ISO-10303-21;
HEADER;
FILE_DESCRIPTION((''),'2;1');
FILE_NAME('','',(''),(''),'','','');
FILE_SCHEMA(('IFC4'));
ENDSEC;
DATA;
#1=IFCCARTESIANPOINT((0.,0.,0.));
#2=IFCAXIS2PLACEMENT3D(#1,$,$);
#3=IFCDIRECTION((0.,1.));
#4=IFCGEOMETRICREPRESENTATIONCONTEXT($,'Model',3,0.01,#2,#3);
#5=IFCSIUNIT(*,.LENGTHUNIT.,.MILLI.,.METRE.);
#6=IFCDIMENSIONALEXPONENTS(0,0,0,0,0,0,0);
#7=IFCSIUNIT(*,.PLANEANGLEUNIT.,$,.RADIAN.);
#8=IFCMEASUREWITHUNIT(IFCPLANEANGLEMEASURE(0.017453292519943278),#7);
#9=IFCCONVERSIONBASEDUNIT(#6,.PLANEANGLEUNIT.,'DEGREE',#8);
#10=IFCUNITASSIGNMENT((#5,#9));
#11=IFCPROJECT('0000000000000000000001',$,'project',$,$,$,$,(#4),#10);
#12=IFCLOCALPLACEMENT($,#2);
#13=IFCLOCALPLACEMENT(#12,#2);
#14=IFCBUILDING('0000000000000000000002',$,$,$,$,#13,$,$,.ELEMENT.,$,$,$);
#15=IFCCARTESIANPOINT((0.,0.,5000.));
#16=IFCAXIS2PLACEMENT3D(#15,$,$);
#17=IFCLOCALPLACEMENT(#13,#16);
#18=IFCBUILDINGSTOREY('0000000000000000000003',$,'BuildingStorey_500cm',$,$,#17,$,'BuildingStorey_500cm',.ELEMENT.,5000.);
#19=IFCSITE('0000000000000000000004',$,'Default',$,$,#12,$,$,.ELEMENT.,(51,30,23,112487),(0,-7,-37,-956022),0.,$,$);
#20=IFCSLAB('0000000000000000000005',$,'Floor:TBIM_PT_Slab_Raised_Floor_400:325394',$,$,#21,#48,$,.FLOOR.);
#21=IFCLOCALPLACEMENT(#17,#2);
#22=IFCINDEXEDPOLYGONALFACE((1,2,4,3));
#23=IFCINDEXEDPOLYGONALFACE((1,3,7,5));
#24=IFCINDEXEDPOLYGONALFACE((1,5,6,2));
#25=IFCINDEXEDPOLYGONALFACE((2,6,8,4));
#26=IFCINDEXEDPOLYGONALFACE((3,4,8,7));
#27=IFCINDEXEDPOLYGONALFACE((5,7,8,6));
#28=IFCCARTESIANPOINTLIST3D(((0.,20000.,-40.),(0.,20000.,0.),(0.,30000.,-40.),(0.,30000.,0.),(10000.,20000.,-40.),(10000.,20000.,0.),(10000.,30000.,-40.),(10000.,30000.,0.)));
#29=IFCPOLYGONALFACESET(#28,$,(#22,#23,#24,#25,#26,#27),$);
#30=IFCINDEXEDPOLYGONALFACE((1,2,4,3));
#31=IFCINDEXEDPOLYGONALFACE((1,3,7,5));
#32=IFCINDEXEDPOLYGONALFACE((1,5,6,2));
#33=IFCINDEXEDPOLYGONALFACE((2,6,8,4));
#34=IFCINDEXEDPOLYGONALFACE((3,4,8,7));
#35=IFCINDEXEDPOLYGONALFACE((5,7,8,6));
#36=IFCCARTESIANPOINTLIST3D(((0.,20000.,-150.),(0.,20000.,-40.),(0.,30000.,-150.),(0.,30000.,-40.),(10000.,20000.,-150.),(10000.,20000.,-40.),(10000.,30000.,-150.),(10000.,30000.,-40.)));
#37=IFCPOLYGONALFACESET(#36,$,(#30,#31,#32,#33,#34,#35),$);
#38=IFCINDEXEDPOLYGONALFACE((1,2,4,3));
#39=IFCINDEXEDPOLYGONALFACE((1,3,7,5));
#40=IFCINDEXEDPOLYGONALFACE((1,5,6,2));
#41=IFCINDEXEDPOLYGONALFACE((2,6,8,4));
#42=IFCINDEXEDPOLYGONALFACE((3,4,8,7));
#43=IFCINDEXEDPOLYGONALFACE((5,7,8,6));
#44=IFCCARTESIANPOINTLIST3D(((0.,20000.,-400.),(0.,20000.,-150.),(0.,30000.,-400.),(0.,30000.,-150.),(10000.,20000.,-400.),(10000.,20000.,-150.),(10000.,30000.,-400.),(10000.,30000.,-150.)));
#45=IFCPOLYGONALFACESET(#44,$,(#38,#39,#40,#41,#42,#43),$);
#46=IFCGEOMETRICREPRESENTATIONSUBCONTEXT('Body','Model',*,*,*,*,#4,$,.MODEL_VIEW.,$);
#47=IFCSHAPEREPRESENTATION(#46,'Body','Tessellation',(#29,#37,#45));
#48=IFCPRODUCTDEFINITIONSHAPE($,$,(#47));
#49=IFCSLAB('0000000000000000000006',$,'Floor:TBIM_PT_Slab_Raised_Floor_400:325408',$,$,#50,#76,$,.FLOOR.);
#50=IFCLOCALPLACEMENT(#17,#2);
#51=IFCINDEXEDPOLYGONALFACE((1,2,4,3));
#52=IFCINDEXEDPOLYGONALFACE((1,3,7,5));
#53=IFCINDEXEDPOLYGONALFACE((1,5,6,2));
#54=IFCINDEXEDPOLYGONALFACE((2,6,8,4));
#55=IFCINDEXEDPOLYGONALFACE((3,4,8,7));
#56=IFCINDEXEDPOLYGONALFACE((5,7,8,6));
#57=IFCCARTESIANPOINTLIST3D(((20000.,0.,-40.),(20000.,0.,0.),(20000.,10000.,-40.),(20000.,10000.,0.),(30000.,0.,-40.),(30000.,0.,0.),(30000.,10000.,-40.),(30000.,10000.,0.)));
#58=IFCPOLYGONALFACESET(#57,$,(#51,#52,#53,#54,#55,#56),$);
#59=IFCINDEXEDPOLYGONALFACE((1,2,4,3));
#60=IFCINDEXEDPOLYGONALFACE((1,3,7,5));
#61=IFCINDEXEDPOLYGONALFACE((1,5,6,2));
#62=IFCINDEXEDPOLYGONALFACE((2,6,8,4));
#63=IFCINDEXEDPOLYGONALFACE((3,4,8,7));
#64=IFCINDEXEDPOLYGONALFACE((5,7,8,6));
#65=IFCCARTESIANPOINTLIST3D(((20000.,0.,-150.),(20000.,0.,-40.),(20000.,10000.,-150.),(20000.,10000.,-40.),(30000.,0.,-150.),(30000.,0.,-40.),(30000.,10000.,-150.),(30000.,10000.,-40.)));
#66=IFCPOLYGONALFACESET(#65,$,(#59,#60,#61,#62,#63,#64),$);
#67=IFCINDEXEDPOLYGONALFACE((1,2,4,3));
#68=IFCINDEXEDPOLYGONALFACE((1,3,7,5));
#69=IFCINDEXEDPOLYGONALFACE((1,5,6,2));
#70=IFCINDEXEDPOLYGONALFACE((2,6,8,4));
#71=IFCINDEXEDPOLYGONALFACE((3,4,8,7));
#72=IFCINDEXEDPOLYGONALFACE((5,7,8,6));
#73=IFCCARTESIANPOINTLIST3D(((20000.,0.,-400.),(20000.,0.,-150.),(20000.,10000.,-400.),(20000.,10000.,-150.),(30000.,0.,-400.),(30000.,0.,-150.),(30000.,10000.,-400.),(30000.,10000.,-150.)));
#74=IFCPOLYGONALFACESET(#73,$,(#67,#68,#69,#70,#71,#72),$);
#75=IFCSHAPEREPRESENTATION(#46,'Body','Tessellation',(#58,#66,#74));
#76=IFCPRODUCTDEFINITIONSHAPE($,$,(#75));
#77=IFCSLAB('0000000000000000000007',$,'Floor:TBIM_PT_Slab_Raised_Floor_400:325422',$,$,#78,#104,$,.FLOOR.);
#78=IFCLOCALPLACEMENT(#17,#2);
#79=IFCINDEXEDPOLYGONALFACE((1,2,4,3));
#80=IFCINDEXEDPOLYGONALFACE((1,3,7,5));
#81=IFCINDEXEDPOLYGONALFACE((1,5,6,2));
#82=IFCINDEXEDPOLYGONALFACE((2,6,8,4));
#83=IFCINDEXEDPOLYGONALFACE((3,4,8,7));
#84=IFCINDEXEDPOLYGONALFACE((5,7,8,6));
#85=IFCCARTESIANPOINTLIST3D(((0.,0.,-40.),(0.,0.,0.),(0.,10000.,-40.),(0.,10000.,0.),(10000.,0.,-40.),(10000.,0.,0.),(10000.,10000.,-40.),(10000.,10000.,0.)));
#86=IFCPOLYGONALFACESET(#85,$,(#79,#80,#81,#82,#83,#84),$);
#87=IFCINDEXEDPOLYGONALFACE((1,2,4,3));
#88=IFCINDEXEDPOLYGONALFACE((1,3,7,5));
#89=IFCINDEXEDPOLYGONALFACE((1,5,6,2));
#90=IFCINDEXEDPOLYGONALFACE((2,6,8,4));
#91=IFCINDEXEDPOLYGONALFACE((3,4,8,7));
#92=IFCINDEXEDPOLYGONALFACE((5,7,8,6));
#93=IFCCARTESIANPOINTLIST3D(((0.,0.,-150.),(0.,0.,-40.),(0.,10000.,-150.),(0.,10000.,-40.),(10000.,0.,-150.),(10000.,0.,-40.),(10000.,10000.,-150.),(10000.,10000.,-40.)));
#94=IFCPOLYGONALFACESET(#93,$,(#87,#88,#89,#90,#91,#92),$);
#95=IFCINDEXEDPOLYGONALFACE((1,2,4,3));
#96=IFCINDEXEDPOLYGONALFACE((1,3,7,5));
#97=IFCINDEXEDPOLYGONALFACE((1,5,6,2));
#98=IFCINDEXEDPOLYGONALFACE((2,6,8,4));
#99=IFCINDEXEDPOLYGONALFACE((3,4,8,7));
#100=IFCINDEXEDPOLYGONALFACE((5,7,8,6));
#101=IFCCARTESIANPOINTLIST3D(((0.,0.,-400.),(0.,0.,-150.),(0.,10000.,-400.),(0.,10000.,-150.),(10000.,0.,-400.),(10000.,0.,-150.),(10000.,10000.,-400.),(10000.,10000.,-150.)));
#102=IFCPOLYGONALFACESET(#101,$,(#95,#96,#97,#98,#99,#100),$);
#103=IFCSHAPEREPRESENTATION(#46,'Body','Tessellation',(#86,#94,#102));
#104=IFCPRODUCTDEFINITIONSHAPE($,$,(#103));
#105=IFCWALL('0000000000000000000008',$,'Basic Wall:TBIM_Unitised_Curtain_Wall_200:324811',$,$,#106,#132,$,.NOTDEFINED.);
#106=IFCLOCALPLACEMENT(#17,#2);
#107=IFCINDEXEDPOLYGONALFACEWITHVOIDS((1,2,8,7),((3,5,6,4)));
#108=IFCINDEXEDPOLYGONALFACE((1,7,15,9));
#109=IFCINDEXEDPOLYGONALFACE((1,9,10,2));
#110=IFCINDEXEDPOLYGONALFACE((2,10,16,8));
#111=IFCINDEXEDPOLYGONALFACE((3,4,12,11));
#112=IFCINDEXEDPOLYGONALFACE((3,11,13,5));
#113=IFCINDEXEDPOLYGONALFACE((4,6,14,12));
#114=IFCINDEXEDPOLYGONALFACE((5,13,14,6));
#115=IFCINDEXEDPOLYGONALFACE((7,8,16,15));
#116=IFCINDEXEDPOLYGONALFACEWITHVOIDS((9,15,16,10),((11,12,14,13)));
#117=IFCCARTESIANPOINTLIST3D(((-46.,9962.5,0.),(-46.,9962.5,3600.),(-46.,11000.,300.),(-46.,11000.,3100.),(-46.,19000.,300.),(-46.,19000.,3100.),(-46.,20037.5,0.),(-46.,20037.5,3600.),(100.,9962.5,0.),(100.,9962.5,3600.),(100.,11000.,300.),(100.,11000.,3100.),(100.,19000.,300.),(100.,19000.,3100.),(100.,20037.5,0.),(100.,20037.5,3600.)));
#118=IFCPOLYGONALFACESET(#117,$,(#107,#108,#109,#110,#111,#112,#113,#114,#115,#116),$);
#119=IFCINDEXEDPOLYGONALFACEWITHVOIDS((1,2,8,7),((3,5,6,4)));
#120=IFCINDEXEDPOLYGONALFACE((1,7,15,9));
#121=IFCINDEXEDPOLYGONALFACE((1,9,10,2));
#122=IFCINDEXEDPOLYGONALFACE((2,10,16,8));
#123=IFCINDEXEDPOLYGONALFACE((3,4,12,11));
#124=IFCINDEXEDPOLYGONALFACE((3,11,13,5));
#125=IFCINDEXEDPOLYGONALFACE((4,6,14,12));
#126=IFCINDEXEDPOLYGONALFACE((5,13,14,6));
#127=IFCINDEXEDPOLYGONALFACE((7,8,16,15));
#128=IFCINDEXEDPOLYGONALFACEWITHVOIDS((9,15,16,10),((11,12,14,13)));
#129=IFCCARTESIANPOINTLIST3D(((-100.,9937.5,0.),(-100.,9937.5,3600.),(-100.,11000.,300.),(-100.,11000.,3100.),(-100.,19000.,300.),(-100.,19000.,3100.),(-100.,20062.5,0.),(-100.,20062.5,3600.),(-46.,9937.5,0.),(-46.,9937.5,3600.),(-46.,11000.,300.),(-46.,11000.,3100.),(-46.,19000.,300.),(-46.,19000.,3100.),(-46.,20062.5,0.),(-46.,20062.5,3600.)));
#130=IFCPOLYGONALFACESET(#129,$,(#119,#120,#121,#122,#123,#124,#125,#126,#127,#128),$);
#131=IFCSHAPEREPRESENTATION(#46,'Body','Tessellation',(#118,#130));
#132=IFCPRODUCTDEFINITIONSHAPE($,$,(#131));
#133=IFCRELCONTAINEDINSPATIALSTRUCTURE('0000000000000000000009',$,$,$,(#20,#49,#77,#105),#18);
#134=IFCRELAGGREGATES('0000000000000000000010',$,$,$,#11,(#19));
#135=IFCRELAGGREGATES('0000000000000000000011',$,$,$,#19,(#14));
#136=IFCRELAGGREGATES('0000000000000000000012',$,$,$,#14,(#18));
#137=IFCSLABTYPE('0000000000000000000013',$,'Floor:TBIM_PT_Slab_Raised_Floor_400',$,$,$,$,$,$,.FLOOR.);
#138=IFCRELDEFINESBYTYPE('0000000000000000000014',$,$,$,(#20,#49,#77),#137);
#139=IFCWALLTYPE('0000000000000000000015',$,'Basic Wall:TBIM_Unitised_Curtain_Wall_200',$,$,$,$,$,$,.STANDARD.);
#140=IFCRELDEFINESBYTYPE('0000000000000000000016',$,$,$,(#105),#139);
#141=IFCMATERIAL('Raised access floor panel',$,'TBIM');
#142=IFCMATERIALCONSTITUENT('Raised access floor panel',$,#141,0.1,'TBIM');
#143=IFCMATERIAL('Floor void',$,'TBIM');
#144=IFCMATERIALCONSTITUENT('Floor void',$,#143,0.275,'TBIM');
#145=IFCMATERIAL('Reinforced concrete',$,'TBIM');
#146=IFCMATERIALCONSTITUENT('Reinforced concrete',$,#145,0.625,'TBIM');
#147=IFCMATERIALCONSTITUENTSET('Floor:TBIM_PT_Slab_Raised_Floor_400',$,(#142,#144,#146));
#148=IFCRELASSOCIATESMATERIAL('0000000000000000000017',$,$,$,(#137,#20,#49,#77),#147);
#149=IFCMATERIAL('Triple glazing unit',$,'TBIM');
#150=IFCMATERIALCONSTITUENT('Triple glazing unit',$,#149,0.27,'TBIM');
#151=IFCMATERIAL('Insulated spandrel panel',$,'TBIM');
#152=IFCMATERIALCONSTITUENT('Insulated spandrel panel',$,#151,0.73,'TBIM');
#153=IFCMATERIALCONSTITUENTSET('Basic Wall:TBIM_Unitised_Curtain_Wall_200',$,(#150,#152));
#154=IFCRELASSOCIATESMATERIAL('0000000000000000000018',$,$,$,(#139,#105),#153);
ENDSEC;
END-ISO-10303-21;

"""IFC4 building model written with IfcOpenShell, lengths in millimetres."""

from ifc_helpers import new_model, entity, si_unit, converted_unit, direction, frame, origin, place, context, subcontext, project, spatial, indexed_curve, outline, extrude, material, constituent, constituent_set, type_object, element, save


model = new_model("IFC4")

# Units and contexts
model_context = context("Model", 3, precision=0.01, world=origin(), true_north=direction((0.0, 1.0)))
body_context = subcontext(model_context, "Body", "Model", "MODEL_VIEW")
ifc_project = project(units=[si_unit("LENGTHUNIT", "METRE", prefix="MILLI"), converted_unit("PLANEANGLEUNIT", "DEGREE", entity("IfcPlaneAngleMeasure", 0.017453292519943278), si_unit("PLANEANGLEUNIT", "RADIAN"), dimensions=[0, 0, 0, 0, 0, 0, 0])], contexts=[model_context])

# Site, building, storey
site_placement = place(None, origin())
site = spatial("IfcSite", under=ifc_project, at=site_placement, Name="Default", CompositionType="ELEMENT", RefLatitude=(51, 30, 23, 112487), RefLongitude=(0, -7, -37, -956022), RefElevation=0.0)
building_placement = place(site_placement, origin())
building = spatial("IfcBuilding", under=site, at=building_placement, CompositionType="ELEMENT")
storey_placement = place(building_placement, frame((0.0, 0.0, 5000.0)))
storey = spatial("IfcBuildingStorey", under=building, at=storey_placement, Name="BuildingStorey_500cm", LongName="BuildingStorey_500cm", CompositionType="ELEMENT", Elevation=5000.0)

# Slabs
ifc_material_1 = material(Name="Raised access floor panel", Category="TBIM")
ifc_constituent_1 = constituent(ifc_material_1, Name="Raised access floor panel", Category="TBIM", fraction=0.1)
ifc_material_2 = material(Name="Floor void", Category="TBIM")
ifc_constituent_2 = constituent(ifc_material_2, Name="Floor void", Category="TBIM", fraction=0.275)
ifc_material_3 = material(Name="Reinforced concrete", Category="TBIM")
ifc_constituent_3 = constituent(ifc_material_3, Name="Reinforced concrete", Category="TBIM", fraction=0.625)
ifc_constituent_set_1 = constituent_set(constituents=[ifc_constituent_1, ifc_constituent_2, ifc_constituent_3], Name="Floor:TBIM_PT_Slab_Raised_Floor_400")
slab_type = type_object("IfcSlabType", Name="Floor:TBIM_PT_Slab_Raised_Floor_400", PredefinedType="FLOOR", material=ifc_constituent_set_1)
slab_1_placement = place(storey_placement, origin())
element("IfcSlab", 1, at=slab_1_placement, inside=storey, type_object=slab_type, material=ifc_constituent_set_1, Name="Floor:TBIM_PT_Slab_Raised_Floor_400:325394", PredefinedType="FLOOR", context=body_context, shape_type="SweptSolid", body=[
    extrude(outline(indexed_curve([(-5000.0, -5000.0), (5000.0, -5000.0), (5000.0, 5000.0), (-5000.0, 5000.0), (-5000.0, -5000.0)], self_intersect=False)), frame((5000.0, 25000.0, -40.0), z_axis=(0.0, 0.0, 1.0), x_axis=(-1.0, 0.0, 0.0)), (0.0, 0.0, 1.0), 40.0),
    extrude(outline(indexed_curve([(-5000.0, -5000.0), (5000.0, -5000.0), (5000.0, 5000.0), (-5000.0, 5000.0), (-5000.0, -5000.0)], self_intersect=False)), frame((5000.0, 25000.0, -150.0), z_axis=(0.0, 0.0, 1.0), x_axis=(-1.0, 0.0, 0.0)), (0.0, 0.0, 1.0), 110.0),
    extrude(outline(indexed_curve([(-5000.0, -5000.0), (5000.0, -5000.0), (5000.0, 5000.0), (-5000.0, 5000.0), (-5000.0, -5000.0)], self_intersect=False)), frame((5000.0, 25000.0, -400.0), z_axis=(0.0, 0.0, 1.0), x_axis=(-1.0, 0.0, 0.0)), (0.0, 0.0, 1.0), 250.0),
])
slab_2_placement = place(storey_placement, origin())
element("IfcSlab", 2, at=slab_2_placement, inside=storey, type_object=slab_type, material=ifc_constituent_set_1, Name="Floor:TBIM_PT_Slab_Raised_Floor_400:325408", PredefinedType="FLOOR", context=body_context, shape_type="SweptSolid", body=[
    extrude(outline(indexed_curve([(-5000.0, -5000.0), (5000.0, -5000.0), (5000.0, 5000.0), (-5000.0, 5000.0), (-5000.0, -5000.0)], self_intersect=False)), frame((25000.0, 5000.0, -40.0), z_axis=(0.0, 0.0, 1.0), x_axis=(-1.0, 0.0, 0.0)), (0.0, 0.0, 1.0), 40.0),
    extrude(outline(indexed_curve([(-5000.0, -5000.0), (5000.0, -5000.0), (5000.0, 5000.0), (-5000.0, 5000.0), (-5000.0, -5000.0)], self_intersect=False)), frame((25000.0, 5000.0, -150.0), z_axis=(0.0, 0.0, 1.0), x_axis=(-1.0, 0.0, 0.0)), (0.0, 0.0, 1.0), 110.0),
    extrude(outline(indexed_curve([(-5000.0, -5000.0), (5000.0, -5000.0), (5000.0, 5000.0), (-5000.0, 5000.0), (-5000.0, -5000.0)], self_intersect=False)), frame((25000.0, 5000.0, -400.0), z_axis=(0.0, 0.0, 1.0), x_axis=(-1.0, 0.0, 0.0)), (0.0, 0.0, 1.0), 250.0),
])
slab_3_placement = place(storey_placement, origin())
element("IfcSlab", 3, at=slab_3_placement, inside=storey, type_object=slab_type, material=ifc_constituent_set_1, Name="Floor:TBIM_PT_Slab_Raised_Floor_400:325422", PredefinedType="FLOOR", context=body_context, shape_type="SweptSolid", body=[
    extrude(outline(indexed_curve([(-5000.0, -5000.0), (5000.0, -5000.0), (5000.0, 5000.0), (-5000.0, 5000.0), (-5000.0, -5000.0)], self_intersect=False)), frame((5000.0, 5000.0, -40.0), z_axis=(0.0, 0.0, 1.0), x_axis=(-1.0, 0.0, 0.0)), (0.0, 0.0, 1.0), 40.0),
    extrude(outline(indexed_curve([(-5000.0, -5000.0), (5000.0, -5000.0), (5000.0, 5000.0), (-5000.0, 5000.0), (-5000.0, -5000.0)], self_intersect=False)), frame((5000.0, 5000.0, -150.0), z_axis=(0.0, 0.0, 1.0), x_axis=(-1.0, 0.0, 0.0)), (0.0, 0.0, 1.0), 110.0),
    extrude(outline(indexed_curve([(-5000.0, -5000.0), (5000.0, -5000.0), (5000.0, 5000.0), (-5000.0, 5000.0), (-5000.0, -5000.0)], self_intersect=False)), frame((5000.0, 5000.0, -400.0), z_axis=(0.0, 0.0, 1.0), x_axis=(-1.0, 0.0, 0.0)), (0.0, 0.0, 1.0), 250.0),
])

# Wall, opening
ifc_material_4 = material(Name="Triple glazing unit", Category="TBIM")
ifc_constituent_4 = constituent(ifc_material_4, Name="Triple glazing unit", Category="TBIM", fraction=0.27)
ifc_material_5 = material(Name="Insulated spandrel panel", Category="TBIM")
ifc_constituent_5 = constituent(ifc_material_5, Name="Insulated spandrel panel", Category="TBIM", fraction=0.73)
ifc_constituent_set_2 = constituent_set(constituents=[ifc_constituent_4, ifc_constituent_5], Name="Basic Wall:TBIM_Unitised_Curtain_Wall_200")
wall_type = type_object("IfcWallType", Name="Basic Wall:TBIM_Unitised_Curtain_Wall_200", PredefinedType="STANDARD", material=ifc_constituent_set_2)
wall_1_placement = place(storey_placement, frame((0.0, 9937.5, 0.0), z_axis=(0.0, 0.0, 1.0), x_axis=(0.0, 1.0, 0.0)))
wall_1 = element("IfcWall", 4, at=wall_1_placement, inside=storey, type_object=wall_type, material=ifc_constituent_set_2, Name="Basic Wall:TBIM_Unitised_Curtain_Wall_200:324811", PredefinedType="NOTDEFINED", context=body_context, shape_type="SweptSolid", body=[
    extrude(outline(indexed_curve([(-1800.0, -5037.5), (1800.0, -5037.5), (1800.0, 5037.5), (-1800.0, 5037.5), (-1800.0, -5037.5)], self_intersect=False), holes=[indexed_curve([(1300.0, 4000.0), (1300.0, -4000.0), (-1500.0, -4000.0), (-1500.0, 4000.0), (1300.0, 4000.0)], self_intersect=False)]), frame((5062.5, 46.0, 1800.0), z_axis=(0.0, -1.0, 0.0), x_axis=(0.0, 0.0, 1.0)), (0.0, 0.0, 1.0), 146.0),
    extrude(outline(indexed_curve([(-5062.5, -1800.0), (5062.5, -1800.0), (5062.5, 1800.0), (-5062.5, 1800.0), (-5062.5, -1800.0)], self_intersect=False), holes=[indexed_curve([(-4000.0, 1300.0), (4000.0, 1300.0), (4000.0, -1500.0), (-4000.0, -1500.0), (-4000.0, 1300.0)], self_intersect=False)]), frame((5062.5, 100.0, 1800.0), z_axis=(0.0, -1.0, 0.0), x_axis=(1.0, 0.0, 0.0)), (0.0, 0.0, 1.0), 54.0),
])
opening_1_placement = place(wall_1_placement, frame((1062.5, -100.0, 300.0)))
element("IfcOpeningElement", 5, at=opening_1_placement, cuts=wall_1, PredefinedType="OPENING", context=body_context, shape_type="SweptSolid", body=[
    extrude(outline(indexed_curve([(2800.0, 0.0), (2800.0, 8000.0), (0.0, 8000.0), (0.0, 0.0), (2800.0, 0.0)], self_intersect=False)), frame((0.0, 0.0, 0.0), z_axis=(0.0, 1.0, 0.0), x_axis=(0.0, 0.0, 1.0)), (0.0, 0.0, 1.0), 200.0),
])

save(model, "model.ifc")
